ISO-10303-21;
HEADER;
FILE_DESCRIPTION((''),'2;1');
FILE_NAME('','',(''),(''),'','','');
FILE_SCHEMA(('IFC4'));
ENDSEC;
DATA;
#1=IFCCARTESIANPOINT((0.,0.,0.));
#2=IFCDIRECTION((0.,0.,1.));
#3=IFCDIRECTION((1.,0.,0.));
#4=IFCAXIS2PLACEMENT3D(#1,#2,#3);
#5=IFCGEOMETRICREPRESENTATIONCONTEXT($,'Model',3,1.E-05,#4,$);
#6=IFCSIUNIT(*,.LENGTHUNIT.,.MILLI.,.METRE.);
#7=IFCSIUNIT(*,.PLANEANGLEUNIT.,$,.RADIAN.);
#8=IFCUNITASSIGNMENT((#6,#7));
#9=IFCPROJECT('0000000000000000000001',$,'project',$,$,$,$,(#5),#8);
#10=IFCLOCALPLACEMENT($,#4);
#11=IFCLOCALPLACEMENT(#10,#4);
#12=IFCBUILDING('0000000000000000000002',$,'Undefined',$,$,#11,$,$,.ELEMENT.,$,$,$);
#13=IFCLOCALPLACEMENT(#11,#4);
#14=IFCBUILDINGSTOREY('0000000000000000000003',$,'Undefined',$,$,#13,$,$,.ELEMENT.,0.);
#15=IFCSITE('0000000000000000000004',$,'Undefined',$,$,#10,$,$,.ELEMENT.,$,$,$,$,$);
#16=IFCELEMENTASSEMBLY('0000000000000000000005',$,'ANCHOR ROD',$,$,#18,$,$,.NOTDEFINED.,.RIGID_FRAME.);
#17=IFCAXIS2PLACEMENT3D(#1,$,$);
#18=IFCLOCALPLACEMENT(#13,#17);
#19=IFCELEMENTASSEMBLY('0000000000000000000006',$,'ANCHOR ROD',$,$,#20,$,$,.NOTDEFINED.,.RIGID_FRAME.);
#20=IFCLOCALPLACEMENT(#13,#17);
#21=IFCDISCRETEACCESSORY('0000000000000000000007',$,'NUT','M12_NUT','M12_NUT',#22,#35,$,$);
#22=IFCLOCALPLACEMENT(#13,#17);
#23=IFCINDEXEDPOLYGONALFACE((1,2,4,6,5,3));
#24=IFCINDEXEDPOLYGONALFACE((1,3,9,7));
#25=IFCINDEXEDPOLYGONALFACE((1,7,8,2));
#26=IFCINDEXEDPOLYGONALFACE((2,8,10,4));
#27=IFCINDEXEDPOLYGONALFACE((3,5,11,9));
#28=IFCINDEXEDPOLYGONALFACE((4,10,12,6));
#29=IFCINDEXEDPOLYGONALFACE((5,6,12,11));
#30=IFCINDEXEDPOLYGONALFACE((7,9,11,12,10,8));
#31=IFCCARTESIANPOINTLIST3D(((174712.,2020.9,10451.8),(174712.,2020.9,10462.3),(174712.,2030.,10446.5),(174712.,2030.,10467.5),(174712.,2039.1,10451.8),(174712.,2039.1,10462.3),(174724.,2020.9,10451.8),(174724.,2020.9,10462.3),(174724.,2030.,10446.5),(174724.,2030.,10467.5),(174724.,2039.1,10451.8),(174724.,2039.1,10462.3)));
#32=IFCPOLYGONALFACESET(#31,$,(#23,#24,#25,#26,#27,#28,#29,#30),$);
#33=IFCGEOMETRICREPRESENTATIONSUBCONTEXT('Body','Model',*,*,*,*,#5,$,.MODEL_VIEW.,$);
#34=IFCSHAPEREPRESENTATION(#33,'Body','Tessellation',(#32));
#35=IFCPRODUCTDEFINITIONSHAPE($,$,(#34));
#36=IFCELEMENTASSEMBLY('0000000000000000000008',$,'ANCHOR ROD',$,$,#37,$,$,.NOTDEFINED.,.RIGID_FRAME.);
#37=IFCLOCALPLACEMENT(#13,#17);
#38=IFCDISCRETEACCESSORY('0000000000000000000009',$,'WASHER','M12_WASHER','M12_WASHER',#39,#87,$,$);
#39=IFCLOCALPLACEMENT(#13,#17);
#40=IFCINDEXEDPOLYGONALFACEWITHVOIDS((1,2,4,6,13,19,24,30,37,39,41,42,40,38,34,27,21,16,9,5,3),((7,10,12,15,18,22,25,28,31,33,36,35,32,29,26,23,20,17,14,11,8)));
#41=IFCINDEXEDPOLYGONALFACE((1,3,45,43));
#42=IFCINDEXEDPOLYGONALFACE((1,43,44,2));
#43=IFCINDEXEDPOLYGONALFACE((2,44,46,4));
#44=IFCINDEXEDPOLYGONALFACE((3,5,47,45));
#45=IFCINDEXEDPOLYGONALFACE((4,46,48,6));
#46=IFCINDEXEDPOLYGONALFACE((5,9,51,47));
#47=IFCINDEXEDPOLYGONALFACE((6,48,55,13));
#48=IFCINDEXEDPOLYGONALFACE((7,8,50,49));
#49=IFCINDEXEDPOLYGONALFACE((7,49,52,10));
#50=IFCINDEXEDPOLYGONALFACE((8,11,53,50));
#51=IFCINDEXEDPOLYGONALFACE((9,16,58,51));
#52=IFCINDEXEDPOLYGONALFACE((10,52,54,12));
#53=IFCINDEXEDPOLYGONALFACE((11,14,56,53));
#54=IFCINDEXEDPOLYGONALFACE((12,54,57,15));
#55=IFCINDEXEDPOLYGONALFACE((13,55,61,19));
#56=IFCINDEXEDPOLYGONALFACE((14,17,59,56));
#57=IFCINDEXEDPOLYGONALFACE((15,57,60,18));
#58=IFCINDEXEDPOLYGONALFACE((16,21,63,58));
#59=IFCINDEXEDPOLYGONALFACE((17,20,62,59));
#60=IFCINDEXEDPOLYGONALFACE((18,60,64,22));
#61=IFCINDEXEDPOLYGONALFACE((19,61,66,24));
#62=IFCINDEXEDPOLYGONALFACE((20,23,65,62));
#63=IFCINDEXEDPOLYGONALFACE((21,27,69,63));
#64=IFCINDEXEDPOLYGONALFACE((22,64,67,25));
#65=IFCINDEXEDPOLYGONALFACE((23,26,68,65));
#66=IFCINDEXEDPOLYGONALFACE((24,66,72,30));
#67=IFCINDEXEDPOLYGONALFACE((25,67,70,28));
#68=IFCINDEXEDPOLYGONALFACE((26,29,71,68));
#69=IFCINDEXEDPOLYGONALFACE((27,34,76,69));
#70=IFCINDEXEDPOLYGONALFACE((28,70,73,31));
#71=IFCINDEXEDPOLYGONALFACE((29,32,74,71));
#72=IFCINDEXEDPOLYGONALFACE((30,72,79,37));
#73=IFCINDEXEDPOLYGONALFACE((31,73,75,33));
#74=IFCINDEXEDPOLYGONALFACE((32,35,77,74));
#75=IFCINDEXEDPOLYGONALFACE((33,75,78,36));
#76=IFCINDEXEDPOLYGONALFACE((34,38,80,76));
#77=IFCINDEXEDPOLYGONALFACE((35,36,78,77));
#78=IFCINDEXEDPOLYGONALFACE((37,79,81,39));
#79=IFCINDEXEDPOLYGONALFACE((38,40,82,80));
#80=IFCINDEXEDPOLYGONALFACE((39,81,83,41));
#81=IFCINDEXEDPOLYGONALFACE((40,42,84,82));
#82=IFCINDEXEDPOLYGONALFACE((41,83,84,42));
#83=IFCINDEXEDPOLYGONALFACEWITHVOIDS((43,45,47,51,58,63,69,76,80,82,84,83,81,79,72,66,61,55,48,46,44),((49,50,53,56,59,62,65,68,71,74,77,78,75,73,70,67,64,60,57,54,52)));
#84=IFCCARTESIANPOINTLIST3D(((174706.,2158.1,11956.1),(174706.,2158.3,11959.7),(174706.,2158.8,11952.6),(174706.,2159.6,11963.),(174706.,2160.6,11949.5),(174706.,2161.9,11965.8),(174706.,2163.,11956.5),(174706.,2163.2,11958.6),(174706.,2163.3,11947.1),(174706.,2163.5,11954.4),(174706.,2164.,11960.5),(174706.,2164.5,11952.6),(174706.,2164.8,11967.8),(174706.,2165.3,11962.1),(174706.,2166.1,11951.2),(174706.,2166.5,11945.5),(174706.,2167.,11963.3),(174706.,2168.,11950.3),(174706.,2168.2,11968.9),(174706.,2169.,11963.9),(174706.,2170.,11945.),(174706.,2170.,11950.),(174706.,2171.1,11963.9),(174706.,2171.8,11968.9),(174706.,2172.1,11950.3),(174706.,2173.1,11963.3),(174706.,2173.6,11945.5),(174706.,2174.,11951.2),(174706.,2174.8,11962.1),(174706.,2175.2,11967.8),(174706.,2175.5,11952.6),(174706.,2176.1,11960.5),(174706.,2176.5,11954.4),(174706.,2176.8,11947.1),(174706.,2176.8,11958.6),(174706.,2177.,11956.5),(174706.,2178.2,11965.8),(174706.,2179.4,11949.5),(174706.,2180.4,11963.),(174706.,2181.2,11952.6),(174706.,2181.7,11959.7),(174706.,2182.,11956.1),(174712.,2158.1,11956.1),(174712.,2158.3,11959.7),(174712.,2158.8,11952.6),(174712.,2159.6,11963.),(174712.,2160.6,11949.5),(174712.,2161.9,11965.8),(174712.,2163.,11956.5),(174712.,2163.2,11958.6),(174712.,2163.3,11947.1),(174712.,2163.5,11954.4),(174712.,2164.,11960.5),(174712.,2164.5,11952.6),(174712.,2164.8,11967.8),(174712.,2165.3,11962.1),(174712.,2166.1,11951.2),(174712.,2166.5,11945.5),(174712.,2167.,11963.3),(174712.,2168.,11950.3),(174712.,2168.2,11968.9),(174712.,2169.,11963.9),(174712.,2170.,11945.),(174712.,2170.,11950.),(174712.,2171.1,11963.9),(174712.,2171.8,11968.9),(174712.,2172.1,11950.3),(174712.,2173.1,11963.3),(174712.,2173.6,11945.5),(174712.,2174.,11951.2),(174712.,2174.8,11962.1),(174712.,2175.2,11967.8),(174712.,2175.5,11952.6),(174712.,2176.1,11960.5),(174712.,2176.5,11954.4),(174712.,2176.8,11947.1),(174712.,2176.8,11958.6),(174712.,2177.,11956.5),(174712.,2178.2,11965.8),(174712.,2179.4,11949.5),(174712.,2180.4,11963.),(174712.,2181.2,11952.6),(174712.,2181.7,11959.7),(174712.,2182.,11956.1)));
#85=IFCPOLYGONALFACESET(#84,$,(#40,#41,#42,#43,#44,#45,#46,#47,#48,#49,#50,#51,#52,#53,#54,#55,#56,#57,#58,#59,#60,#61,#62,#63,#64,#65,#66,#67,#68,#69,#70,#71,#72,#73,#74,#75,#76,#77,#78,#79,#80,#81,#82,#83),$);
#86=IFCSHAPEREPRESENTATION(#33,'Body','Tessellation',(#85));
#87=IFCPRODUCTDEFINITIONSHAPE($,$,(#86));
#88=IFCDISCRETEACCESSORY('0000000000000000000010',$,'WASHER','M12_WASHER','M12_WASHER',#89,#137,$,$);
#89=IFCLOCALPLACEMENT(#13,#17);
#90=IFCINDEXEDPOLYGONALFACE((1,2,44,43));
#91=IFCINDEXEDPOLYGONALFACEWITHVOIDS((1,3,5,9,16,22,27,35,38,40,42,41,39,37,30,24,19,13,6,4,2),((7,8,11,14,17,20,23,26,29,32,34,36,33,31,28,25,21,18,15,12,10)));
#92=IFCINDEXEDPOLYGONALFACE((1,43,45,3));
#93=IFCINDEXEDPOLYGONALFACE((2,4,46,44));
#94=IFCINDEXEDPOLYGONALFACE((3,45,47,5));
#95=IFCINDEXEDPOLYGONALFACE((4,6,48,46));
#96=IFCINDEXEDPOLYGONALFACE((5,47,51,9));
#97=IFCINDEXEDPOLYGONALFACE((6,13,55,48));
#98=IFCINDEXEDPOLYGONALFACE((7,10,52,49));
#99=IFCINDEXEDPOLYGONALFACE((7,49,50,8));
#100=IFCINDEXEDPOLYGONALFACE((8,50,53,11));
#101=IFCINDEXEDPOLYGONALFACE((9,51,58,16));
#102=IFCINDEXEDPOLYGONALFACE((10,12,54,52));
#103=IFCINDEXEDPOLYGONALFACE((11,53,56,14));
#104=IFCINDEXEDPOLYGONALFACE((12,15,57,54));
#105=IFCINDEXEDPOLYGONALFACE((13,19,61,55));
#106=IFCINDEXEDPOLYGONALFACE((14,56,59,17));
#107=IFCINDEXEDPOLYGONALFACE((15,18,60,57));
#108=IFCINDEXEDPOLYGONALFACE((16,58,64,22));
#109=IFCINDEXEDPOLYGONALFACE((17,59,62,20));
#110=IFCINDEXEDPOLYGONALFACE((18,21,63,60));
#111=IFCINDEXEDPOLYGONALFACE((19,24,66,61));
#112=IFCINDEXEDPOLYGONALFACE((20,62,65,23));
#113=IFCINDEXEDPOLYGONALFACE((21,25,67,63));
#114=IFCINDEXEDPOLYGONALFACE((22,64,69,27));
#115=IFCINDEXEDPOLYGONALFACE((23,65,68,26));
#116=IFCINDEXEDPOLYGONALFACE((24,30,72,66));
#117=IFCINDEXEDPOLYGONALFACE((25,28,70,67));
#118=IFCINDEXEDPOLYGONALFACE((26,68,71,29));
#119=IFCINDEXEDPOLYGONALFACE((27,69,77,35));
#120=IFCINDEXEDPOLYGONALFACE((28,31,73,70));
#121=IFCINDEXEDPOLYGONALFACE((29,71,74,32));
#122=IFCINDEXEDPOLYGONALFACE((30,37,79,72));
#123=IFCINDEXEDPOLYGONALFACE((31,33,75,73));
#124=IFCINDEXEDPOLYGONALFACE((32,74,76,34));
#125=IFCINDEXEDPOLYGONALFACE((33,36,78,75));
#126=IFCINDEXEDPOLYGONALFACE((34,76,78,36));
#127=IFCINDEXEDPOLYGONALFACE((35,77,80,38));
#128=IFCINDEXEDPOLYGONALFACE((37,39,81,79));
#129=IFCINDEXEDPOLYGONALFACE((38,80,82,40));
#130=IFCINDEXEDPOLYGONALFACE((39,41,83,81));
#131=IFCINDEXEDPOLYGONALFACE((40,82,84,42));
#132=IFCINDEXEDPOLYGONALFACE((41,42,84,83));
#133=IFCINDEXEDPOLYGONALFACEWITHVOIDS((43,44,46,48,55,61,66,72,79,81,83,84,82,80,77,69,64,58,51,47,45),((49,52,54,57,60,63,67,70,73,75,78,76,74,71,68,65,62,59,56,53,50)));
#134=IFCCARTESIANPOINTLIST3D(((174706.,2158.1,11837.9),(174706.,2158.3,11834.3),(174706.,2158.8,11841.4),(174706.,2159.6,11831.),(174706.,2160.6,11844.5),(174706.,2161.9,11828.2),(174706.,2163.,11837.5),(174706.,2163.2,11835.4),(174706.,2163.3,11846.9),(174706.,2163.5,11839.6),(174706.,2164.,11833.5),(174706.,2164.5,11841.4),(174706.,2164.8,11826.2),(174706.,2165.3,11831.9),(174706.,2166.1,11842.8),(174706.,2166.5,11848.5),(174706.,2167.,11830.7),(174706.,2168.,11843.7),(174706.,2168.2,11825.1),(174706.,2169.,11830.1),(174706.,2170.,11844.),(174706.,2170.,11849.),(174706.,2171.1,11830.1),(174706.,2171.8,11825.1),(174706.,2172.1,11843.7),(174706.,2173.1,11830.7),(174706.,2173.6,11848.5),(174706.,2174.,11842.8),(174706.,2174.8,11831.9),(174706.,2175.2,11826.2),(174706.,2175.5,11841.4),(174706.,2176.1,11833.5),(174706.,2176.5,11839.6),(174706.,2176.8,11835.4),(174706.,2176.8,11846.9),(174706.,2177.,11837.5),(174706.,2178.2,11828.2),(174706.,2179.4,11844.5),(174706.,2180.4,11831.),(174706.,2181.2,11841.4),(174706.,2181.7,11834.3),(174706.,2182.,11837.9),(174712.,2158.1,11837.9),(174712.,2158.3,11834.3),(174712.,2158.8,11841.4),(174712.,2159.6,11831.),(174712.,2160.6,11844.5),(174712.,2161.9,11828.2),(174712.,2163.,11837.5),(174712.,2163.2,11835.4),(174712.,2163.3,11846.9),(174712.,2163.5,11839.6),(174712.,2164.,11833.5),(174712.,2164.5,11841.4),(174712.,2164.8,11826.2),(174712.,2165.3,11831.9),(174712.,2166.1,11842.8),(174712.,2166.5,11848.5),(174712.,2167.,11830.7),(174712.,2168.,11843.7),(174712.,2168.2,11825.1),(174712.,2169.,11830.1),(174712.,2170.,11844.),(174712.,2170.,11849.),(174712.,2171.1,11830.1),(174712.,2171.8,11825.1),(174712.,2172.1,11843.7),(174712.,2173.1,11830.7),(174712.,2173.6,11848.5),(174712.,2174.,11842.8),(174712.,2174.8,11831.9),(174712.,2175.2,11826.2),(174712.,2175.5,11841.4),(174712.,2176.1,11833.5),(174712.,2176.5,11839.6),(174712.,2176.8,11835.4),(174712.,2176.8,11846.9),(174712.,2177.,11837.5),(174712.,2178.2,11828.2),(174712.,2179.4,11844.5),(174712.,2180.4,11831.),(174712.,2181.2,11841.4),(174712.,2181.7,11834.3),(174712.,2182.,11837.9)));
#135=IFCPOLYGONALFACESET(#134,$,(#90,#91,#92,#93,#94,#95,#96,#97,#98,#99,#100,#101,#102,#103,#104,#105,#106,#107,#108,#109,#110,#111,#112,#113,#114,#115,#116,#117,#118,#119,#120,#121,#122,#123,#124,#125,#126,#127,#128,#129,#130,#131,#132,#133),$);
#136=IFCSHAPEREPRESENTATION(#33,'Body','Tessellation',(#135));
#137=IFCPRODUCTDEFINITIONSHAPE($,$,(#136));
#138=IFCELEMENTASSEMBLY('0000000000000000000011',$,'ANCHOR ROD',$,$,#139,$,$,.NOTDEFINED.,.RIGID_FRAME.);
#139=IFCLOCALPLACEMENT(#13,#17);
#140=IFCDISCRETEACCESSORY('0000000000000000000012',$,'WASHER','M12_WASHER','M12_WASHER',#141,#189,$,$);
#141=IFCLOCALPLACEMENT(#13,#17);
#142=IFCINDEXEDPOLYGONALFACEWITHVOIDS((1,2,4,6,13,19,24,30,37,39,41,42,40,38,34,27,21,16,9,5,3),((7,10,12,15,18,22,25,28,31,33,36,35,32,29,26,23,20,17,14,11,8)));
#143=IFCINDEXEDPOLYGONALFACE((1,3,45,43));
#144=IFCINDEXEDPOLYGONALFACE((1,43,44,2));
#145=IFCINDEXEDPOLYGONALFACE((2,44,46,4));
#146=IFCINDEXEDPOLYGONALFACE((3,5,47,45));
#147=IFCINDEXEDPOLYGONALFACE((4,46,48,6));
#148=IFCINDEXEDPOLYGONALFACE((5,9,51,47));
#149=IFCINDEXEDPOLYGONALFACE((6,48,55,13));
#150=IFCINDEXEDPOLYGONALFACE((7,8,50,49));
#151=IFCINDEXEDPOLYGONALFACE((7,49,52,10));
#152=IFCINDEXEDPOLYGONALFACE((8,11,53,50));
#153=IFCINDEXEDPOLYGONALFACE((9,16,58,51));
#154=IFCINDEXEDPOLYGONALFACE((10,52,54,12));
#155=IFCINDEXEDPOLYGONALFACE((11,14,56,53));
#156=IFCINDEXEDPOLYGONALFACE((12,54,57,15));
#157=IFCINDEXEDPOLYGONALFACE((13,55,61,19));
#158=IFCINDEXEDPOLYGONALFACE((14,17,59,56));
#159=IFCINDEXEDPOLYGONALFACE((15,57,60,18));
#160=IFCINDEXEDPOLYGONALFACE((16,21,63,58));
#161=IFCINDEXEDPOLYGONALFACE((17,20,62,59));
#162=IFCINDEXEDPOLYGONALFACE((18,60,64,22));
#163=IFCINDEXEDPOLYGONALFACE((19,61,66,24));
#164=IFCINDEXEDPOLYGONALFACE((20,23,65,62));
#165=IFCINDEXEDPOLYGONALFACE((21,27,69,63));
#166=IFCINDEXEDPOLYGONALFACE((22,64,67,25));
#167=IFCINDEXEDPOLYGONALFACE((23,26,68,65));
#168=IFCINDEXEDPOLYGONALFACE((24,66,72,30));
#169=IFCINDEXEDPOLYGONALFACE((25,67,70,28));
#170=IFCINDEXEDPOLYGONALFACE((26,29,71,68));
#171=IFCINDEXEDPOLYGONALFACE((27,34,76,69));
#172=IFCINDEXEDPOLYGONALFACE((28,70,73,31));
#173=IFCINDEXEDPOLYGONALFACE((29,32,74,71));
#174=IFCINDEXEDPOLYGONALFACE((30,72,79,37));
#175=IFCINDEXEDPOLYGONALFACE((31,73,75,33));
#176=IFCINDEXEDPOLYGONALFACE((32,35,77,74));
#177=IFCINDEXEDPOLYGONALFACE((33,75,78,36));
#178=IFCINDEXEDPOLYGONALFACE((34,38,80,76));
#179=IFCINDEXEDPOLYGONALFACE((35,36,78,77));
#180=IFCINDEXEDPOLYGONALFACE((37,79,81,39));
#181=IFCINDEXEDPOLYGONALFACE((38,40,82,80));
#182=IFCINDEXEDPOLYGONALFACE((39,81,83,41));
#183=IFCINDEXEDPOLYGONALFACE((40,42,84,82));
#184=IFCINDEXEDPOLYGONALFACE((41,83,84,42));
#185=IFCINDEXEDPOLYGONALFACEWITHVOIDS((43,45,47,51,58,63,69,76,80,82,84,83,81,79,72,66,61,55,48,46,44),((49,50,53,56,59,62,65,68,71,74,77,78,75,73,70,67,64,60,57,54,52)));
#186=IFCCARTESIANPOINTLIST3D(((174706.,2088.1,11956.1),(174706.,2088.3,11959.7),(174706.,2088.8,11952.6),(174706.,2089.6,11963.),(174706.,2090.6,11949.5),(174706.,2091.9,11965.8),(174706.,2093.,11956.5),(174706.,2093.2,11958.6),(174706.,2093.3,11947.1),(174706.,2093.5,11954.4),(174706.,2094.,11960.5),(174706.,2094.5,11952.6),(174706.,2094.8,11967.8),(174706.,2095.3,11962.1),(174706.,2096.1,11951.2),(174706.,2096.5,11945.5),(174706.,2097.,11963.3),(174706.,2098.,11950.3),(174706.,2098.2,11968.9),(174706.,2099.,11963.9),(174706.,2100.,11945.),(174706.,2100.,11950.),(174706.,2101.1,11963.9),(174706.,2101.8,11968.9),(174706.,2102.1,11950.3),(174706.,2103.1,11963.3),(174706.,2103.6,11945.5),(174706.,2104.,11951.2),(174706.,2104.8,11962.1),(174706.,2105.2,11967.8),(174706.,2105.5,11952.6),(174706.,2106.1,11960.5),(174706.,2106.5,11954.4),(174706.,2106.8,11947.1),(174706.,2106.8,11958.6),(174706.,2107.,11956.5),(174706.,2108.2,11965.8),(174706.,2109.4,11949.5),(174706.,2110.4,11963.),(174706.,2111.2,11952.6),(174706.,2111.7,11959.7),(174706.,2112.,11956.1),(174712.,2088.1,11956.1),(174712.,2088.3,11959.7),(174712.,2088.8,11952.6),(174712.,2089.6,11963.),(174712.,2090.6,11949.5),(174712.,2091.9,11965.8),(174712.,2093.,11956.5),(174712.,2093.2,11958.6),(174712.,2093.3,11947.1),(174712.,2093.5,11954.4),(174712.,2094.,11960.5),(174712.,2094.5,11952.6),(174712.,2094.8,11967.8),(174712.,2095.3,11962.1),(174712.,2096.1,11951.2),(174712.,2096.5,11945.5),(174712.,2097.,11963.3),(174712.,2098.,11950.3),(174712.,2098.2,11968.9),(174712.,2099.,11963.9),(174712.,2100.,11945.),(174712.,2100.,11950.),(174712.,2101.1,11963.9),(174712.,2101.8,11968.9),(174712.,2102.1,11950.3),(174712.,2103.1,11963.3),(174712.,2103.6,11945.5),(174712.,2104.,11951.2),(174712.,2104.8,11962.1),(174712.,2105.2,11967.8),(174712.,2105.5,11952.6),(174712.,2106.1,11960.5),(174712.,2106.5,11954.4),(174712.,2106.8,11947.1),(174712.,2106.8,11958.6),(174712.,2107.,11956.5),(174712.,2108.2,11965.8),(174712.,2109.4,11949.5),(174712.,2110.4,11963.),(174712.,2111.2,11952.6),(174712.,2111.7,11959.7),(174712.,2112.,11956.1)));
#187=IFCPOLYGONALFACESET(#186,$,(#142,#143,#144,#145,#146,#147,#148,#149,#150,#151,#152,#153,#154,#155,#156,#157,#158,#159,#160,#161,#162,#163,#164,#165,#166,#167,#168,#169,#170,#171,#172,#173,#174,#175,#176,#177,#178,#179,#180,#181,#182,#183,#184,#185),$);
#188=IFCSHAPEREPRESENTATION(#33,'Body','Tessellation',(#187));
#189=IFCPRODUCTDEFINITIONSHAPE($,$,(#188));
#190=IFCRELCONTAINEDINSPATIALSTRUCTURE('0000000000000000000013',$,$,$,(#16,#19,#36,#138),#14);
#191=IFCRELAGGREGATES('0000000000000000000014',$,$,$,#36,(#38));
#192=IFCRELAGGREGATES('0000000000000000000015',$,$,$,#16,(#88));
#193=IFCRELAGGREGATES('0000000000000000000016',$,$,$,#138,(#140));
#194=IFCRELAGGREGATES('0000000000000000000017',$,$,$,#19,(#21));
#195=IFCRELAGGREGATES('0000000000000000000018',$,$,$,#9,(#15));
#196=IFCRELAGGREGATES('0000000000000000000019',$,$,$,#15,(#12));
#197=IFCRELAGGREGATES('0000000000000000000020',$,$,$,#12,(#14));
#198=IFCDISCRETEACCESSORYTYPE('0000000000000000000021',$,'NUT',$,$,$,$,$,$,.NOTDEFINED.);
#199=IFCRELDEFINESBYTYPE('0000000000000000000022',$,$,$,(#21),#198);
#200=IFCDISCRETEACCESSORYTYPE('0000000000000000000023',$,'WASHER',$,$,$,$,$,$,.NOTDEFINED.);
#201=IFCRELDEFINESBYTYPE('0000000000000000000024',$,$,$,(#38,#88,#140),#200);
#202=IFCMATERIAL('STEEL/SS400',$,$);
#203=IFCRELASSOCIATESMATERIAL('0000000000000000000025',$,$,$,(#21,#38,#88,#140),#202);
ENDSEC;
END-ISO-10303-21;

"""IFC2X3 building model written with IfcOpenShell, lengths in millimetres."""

from ifc_helpers import new_model, si_unit, frame, origin_with_axes, origin_2d_with_axis, place, context, subcontext, project, spatial, polyline, hollow_circle, outline, extrude, material, type_object, element, aggregate, save


model = new_model("IFC2X3")

# Units and contexts
model_context = context("Model", 3, precision=1e-05, world=origin_with_axes())
body_context = subcontext(model_context, "Body", "Model", "MODEL_VIEW")
ifc_project = project(units=[si_unit("LENGTHUNIT", "METRE", prefix="MILLI"), si_unit("PLANEANGLEUNIT", "RADIAN")], contexts=[model_context])

# Site, building, storey
site_placement = place(None, origin_with_axes())
site = spatial("IfcSite", under=ifc_project, at=site_placement, Name="Undefined", CompositionType="ELEMENT")
building_placement = place(site_placement, origin_with_axes())
building = spatial("IfcBuilding", under=site, at=building_placement, Name="Undefined", CompositionType="ELEMENT")
storey_placement = place(building_placement, origin_with_axes())
storey = spatial("IfcBuildingStorey", under=building, at=storey_placement, Name="Undefined", CompositionType="ELEMENT", Elevation=0.0)

# Shared definitions
ifc_material_1 = material(Name="STEEL/SS400")

# Element assemblies, discrete accessories
assembly_1_placement = place(storey_placement, origin_with_axes())
assembly_1 = element("IfcElementAssembly", 1, at=assembly_1_placement, inside=storey, Name="ANCHOR ROD", AssemblyPlace="NOTDEFINED", PredefinedType="RIGID_FRAME")
discrete_accessory_type_1 = type_object("IfcDiscreteAccessoryType", Name="NUT")
assembly_2_placement = place(storey_placement, origin_with_axes())
assembly_2 = element("IfcElementAssembly", 2, at=assembly_2_placement, inside=storey, Name="ANCHOR ROD", AssemblyPlace="NOTDEFINED", PredefinedType="RIGID_FRAME")
discrete_accessory_1_placement = place(assembly_2_placement, frame((174724.0, 2030.0, 10457.0), z_axis=(0.0, 1.0, 0.0), x_axis=(-1.0, 0.0, 0.0)))
discrete_accessory_1 = element("IfcDiscreteAccessory", 3, at=discrete_accessory_1_placement, type_object=discrete_accessory_type_1, material=ifc_material_1, Name="NUT", Description="M12_NUT", ObjectType="M12_NUT", context=body_context, shape_type="SweptSolid", body=[
    extrude(outline(polyline([(-5.2, -9.1), (-10.5, 0.0), (-5.2, 9.1), (5.3, 9.1), (10.5, 0.0), (5.3, -9.1), (-5.2, -9.1)])), frame((12.0, 0.0, 0.0), z_axis=(-1.0, 0.0, 0.0), x_axis=(0.0, -1.0, 0.0)), (0.0, 0.0, 1.0), 12.0),
])
assembly_3_placement = place(storey_placement, origin_with_axes())
assembly_3 = element("IfcElementAssembly", 4, at=assembly_3_placement, inside=storey, Name="ANCHOR ROD", AssemblyPlace="NOTDEFINED", PredefinedType="RIGID_FRAME")
discrete_accessory_type_2 = type_object("IfcDiscreteAccessoryType", Name="WASHER")
discrete_accessory_2_placement = place(assembly_3_placement, frame((174712.0, 2170.0, 11957.0), z_axis=(0.0, 1.0, 0.0), x_axis=(-1.0, 0.0, 0.0)))
discrete_accessory_2 = element("IfcDiscreteAccessory", 5, at=discrete_accessory_2_placement, type_object=discrete_accessory_type_2, material=ifc_material_1, Name="WASHER", Description="M12_WASHER", ObjectType="M12_WASHER", context=body_context, shape_type="SweptSolid", body=[
    extrude(hollow_circle(Radius=12.0, WallThickness=5.0, at=origin_2d_with_axis()), frame((6.0, 0.0, 0.0), z_axis=(-1.0, 0.0, 0.0), x_axis=(0.0, -1.0, 0.0)), (0.0, 0.0, 1.0), 6.0),
])
aggregate(assembly_3, [discrete_accessory_2])

# Discrete accessory
discrete_accessory_3_placement = place(assembly_1_placement, frame((174712.0, 2170.0, 11837.0), z_axis=(0.0, -1.0, 0.0), x_axis=(-1.0, 0.0, 0.0)))
discrete_accessory_3 = element("IfcDiscreteAccessory", 6, at=discrete_accessory_3_placement, type_object=discrete_accessory_type_2, material=ifc_material_1, Name="WASHER", Description="M12_WASHER", ObjectType="M12_WASHER", context=body_context, shape_type="SweptSolid", body=[
    extrude(hollow_circle(Radius=12.0, WallThickness=5.0, at=origin_2d_with_axis()), frame((6.0, 0.0, 0.0), z_axis=(-1.0, 0.0, 0.0), x_axis=(0.0, -1.0, 0.0)), (0.0, 0.0, 1.0), 6.0),
])
aggregate(assembly_1, [discrete_accessory_3])

# Element assembly, discrete accessory
assembly_4_placement = place(storey_placement, origin_with_axes())
assembly_4 = element("IfcElementAssembly", 7, at=assembly_4_placement, inside=storey, Name="ANCHOR ROD", AssemblyPlace="NOTDEFINED", PredefinedType="RIGID_FRAME")
discrete_accessory_4_placement = place(assembly_4_placement, frame((174712.0, 2100.0, 11957.0), z_axis=(0.0, 1.0, 0.0), x_axis=(-1.0, 0.0, 0.0)))
discrete_accessory_4 = element("IfcDiscreteAccessory", 8, at=discrete_accessory_4_placement, type_object=discrete_accessory_type_2, material=ifc_material_1, Name="WASHER", Description="M12_WASHER", ObjectType="M12_WASHER", context=body_context, shape_type="SweptSolid", body=[
    extrude(hollow_circle(Radius=12.0, WallThickness=5.0, at=origin_2d_with_axis()), frame((6.0, 0.0, 0.0), z_axis=(-1.0, 0.0, 0.0), x_axis=(0.0, -1.0, 0.0)), (0.0, 0.0, 1.0), 6.0),
])
aggregate(assembly_4, [discrete_accessory_4])

aggregate(assembly_2, [discrete_accessory_1])

save(model, "model.ifc")
